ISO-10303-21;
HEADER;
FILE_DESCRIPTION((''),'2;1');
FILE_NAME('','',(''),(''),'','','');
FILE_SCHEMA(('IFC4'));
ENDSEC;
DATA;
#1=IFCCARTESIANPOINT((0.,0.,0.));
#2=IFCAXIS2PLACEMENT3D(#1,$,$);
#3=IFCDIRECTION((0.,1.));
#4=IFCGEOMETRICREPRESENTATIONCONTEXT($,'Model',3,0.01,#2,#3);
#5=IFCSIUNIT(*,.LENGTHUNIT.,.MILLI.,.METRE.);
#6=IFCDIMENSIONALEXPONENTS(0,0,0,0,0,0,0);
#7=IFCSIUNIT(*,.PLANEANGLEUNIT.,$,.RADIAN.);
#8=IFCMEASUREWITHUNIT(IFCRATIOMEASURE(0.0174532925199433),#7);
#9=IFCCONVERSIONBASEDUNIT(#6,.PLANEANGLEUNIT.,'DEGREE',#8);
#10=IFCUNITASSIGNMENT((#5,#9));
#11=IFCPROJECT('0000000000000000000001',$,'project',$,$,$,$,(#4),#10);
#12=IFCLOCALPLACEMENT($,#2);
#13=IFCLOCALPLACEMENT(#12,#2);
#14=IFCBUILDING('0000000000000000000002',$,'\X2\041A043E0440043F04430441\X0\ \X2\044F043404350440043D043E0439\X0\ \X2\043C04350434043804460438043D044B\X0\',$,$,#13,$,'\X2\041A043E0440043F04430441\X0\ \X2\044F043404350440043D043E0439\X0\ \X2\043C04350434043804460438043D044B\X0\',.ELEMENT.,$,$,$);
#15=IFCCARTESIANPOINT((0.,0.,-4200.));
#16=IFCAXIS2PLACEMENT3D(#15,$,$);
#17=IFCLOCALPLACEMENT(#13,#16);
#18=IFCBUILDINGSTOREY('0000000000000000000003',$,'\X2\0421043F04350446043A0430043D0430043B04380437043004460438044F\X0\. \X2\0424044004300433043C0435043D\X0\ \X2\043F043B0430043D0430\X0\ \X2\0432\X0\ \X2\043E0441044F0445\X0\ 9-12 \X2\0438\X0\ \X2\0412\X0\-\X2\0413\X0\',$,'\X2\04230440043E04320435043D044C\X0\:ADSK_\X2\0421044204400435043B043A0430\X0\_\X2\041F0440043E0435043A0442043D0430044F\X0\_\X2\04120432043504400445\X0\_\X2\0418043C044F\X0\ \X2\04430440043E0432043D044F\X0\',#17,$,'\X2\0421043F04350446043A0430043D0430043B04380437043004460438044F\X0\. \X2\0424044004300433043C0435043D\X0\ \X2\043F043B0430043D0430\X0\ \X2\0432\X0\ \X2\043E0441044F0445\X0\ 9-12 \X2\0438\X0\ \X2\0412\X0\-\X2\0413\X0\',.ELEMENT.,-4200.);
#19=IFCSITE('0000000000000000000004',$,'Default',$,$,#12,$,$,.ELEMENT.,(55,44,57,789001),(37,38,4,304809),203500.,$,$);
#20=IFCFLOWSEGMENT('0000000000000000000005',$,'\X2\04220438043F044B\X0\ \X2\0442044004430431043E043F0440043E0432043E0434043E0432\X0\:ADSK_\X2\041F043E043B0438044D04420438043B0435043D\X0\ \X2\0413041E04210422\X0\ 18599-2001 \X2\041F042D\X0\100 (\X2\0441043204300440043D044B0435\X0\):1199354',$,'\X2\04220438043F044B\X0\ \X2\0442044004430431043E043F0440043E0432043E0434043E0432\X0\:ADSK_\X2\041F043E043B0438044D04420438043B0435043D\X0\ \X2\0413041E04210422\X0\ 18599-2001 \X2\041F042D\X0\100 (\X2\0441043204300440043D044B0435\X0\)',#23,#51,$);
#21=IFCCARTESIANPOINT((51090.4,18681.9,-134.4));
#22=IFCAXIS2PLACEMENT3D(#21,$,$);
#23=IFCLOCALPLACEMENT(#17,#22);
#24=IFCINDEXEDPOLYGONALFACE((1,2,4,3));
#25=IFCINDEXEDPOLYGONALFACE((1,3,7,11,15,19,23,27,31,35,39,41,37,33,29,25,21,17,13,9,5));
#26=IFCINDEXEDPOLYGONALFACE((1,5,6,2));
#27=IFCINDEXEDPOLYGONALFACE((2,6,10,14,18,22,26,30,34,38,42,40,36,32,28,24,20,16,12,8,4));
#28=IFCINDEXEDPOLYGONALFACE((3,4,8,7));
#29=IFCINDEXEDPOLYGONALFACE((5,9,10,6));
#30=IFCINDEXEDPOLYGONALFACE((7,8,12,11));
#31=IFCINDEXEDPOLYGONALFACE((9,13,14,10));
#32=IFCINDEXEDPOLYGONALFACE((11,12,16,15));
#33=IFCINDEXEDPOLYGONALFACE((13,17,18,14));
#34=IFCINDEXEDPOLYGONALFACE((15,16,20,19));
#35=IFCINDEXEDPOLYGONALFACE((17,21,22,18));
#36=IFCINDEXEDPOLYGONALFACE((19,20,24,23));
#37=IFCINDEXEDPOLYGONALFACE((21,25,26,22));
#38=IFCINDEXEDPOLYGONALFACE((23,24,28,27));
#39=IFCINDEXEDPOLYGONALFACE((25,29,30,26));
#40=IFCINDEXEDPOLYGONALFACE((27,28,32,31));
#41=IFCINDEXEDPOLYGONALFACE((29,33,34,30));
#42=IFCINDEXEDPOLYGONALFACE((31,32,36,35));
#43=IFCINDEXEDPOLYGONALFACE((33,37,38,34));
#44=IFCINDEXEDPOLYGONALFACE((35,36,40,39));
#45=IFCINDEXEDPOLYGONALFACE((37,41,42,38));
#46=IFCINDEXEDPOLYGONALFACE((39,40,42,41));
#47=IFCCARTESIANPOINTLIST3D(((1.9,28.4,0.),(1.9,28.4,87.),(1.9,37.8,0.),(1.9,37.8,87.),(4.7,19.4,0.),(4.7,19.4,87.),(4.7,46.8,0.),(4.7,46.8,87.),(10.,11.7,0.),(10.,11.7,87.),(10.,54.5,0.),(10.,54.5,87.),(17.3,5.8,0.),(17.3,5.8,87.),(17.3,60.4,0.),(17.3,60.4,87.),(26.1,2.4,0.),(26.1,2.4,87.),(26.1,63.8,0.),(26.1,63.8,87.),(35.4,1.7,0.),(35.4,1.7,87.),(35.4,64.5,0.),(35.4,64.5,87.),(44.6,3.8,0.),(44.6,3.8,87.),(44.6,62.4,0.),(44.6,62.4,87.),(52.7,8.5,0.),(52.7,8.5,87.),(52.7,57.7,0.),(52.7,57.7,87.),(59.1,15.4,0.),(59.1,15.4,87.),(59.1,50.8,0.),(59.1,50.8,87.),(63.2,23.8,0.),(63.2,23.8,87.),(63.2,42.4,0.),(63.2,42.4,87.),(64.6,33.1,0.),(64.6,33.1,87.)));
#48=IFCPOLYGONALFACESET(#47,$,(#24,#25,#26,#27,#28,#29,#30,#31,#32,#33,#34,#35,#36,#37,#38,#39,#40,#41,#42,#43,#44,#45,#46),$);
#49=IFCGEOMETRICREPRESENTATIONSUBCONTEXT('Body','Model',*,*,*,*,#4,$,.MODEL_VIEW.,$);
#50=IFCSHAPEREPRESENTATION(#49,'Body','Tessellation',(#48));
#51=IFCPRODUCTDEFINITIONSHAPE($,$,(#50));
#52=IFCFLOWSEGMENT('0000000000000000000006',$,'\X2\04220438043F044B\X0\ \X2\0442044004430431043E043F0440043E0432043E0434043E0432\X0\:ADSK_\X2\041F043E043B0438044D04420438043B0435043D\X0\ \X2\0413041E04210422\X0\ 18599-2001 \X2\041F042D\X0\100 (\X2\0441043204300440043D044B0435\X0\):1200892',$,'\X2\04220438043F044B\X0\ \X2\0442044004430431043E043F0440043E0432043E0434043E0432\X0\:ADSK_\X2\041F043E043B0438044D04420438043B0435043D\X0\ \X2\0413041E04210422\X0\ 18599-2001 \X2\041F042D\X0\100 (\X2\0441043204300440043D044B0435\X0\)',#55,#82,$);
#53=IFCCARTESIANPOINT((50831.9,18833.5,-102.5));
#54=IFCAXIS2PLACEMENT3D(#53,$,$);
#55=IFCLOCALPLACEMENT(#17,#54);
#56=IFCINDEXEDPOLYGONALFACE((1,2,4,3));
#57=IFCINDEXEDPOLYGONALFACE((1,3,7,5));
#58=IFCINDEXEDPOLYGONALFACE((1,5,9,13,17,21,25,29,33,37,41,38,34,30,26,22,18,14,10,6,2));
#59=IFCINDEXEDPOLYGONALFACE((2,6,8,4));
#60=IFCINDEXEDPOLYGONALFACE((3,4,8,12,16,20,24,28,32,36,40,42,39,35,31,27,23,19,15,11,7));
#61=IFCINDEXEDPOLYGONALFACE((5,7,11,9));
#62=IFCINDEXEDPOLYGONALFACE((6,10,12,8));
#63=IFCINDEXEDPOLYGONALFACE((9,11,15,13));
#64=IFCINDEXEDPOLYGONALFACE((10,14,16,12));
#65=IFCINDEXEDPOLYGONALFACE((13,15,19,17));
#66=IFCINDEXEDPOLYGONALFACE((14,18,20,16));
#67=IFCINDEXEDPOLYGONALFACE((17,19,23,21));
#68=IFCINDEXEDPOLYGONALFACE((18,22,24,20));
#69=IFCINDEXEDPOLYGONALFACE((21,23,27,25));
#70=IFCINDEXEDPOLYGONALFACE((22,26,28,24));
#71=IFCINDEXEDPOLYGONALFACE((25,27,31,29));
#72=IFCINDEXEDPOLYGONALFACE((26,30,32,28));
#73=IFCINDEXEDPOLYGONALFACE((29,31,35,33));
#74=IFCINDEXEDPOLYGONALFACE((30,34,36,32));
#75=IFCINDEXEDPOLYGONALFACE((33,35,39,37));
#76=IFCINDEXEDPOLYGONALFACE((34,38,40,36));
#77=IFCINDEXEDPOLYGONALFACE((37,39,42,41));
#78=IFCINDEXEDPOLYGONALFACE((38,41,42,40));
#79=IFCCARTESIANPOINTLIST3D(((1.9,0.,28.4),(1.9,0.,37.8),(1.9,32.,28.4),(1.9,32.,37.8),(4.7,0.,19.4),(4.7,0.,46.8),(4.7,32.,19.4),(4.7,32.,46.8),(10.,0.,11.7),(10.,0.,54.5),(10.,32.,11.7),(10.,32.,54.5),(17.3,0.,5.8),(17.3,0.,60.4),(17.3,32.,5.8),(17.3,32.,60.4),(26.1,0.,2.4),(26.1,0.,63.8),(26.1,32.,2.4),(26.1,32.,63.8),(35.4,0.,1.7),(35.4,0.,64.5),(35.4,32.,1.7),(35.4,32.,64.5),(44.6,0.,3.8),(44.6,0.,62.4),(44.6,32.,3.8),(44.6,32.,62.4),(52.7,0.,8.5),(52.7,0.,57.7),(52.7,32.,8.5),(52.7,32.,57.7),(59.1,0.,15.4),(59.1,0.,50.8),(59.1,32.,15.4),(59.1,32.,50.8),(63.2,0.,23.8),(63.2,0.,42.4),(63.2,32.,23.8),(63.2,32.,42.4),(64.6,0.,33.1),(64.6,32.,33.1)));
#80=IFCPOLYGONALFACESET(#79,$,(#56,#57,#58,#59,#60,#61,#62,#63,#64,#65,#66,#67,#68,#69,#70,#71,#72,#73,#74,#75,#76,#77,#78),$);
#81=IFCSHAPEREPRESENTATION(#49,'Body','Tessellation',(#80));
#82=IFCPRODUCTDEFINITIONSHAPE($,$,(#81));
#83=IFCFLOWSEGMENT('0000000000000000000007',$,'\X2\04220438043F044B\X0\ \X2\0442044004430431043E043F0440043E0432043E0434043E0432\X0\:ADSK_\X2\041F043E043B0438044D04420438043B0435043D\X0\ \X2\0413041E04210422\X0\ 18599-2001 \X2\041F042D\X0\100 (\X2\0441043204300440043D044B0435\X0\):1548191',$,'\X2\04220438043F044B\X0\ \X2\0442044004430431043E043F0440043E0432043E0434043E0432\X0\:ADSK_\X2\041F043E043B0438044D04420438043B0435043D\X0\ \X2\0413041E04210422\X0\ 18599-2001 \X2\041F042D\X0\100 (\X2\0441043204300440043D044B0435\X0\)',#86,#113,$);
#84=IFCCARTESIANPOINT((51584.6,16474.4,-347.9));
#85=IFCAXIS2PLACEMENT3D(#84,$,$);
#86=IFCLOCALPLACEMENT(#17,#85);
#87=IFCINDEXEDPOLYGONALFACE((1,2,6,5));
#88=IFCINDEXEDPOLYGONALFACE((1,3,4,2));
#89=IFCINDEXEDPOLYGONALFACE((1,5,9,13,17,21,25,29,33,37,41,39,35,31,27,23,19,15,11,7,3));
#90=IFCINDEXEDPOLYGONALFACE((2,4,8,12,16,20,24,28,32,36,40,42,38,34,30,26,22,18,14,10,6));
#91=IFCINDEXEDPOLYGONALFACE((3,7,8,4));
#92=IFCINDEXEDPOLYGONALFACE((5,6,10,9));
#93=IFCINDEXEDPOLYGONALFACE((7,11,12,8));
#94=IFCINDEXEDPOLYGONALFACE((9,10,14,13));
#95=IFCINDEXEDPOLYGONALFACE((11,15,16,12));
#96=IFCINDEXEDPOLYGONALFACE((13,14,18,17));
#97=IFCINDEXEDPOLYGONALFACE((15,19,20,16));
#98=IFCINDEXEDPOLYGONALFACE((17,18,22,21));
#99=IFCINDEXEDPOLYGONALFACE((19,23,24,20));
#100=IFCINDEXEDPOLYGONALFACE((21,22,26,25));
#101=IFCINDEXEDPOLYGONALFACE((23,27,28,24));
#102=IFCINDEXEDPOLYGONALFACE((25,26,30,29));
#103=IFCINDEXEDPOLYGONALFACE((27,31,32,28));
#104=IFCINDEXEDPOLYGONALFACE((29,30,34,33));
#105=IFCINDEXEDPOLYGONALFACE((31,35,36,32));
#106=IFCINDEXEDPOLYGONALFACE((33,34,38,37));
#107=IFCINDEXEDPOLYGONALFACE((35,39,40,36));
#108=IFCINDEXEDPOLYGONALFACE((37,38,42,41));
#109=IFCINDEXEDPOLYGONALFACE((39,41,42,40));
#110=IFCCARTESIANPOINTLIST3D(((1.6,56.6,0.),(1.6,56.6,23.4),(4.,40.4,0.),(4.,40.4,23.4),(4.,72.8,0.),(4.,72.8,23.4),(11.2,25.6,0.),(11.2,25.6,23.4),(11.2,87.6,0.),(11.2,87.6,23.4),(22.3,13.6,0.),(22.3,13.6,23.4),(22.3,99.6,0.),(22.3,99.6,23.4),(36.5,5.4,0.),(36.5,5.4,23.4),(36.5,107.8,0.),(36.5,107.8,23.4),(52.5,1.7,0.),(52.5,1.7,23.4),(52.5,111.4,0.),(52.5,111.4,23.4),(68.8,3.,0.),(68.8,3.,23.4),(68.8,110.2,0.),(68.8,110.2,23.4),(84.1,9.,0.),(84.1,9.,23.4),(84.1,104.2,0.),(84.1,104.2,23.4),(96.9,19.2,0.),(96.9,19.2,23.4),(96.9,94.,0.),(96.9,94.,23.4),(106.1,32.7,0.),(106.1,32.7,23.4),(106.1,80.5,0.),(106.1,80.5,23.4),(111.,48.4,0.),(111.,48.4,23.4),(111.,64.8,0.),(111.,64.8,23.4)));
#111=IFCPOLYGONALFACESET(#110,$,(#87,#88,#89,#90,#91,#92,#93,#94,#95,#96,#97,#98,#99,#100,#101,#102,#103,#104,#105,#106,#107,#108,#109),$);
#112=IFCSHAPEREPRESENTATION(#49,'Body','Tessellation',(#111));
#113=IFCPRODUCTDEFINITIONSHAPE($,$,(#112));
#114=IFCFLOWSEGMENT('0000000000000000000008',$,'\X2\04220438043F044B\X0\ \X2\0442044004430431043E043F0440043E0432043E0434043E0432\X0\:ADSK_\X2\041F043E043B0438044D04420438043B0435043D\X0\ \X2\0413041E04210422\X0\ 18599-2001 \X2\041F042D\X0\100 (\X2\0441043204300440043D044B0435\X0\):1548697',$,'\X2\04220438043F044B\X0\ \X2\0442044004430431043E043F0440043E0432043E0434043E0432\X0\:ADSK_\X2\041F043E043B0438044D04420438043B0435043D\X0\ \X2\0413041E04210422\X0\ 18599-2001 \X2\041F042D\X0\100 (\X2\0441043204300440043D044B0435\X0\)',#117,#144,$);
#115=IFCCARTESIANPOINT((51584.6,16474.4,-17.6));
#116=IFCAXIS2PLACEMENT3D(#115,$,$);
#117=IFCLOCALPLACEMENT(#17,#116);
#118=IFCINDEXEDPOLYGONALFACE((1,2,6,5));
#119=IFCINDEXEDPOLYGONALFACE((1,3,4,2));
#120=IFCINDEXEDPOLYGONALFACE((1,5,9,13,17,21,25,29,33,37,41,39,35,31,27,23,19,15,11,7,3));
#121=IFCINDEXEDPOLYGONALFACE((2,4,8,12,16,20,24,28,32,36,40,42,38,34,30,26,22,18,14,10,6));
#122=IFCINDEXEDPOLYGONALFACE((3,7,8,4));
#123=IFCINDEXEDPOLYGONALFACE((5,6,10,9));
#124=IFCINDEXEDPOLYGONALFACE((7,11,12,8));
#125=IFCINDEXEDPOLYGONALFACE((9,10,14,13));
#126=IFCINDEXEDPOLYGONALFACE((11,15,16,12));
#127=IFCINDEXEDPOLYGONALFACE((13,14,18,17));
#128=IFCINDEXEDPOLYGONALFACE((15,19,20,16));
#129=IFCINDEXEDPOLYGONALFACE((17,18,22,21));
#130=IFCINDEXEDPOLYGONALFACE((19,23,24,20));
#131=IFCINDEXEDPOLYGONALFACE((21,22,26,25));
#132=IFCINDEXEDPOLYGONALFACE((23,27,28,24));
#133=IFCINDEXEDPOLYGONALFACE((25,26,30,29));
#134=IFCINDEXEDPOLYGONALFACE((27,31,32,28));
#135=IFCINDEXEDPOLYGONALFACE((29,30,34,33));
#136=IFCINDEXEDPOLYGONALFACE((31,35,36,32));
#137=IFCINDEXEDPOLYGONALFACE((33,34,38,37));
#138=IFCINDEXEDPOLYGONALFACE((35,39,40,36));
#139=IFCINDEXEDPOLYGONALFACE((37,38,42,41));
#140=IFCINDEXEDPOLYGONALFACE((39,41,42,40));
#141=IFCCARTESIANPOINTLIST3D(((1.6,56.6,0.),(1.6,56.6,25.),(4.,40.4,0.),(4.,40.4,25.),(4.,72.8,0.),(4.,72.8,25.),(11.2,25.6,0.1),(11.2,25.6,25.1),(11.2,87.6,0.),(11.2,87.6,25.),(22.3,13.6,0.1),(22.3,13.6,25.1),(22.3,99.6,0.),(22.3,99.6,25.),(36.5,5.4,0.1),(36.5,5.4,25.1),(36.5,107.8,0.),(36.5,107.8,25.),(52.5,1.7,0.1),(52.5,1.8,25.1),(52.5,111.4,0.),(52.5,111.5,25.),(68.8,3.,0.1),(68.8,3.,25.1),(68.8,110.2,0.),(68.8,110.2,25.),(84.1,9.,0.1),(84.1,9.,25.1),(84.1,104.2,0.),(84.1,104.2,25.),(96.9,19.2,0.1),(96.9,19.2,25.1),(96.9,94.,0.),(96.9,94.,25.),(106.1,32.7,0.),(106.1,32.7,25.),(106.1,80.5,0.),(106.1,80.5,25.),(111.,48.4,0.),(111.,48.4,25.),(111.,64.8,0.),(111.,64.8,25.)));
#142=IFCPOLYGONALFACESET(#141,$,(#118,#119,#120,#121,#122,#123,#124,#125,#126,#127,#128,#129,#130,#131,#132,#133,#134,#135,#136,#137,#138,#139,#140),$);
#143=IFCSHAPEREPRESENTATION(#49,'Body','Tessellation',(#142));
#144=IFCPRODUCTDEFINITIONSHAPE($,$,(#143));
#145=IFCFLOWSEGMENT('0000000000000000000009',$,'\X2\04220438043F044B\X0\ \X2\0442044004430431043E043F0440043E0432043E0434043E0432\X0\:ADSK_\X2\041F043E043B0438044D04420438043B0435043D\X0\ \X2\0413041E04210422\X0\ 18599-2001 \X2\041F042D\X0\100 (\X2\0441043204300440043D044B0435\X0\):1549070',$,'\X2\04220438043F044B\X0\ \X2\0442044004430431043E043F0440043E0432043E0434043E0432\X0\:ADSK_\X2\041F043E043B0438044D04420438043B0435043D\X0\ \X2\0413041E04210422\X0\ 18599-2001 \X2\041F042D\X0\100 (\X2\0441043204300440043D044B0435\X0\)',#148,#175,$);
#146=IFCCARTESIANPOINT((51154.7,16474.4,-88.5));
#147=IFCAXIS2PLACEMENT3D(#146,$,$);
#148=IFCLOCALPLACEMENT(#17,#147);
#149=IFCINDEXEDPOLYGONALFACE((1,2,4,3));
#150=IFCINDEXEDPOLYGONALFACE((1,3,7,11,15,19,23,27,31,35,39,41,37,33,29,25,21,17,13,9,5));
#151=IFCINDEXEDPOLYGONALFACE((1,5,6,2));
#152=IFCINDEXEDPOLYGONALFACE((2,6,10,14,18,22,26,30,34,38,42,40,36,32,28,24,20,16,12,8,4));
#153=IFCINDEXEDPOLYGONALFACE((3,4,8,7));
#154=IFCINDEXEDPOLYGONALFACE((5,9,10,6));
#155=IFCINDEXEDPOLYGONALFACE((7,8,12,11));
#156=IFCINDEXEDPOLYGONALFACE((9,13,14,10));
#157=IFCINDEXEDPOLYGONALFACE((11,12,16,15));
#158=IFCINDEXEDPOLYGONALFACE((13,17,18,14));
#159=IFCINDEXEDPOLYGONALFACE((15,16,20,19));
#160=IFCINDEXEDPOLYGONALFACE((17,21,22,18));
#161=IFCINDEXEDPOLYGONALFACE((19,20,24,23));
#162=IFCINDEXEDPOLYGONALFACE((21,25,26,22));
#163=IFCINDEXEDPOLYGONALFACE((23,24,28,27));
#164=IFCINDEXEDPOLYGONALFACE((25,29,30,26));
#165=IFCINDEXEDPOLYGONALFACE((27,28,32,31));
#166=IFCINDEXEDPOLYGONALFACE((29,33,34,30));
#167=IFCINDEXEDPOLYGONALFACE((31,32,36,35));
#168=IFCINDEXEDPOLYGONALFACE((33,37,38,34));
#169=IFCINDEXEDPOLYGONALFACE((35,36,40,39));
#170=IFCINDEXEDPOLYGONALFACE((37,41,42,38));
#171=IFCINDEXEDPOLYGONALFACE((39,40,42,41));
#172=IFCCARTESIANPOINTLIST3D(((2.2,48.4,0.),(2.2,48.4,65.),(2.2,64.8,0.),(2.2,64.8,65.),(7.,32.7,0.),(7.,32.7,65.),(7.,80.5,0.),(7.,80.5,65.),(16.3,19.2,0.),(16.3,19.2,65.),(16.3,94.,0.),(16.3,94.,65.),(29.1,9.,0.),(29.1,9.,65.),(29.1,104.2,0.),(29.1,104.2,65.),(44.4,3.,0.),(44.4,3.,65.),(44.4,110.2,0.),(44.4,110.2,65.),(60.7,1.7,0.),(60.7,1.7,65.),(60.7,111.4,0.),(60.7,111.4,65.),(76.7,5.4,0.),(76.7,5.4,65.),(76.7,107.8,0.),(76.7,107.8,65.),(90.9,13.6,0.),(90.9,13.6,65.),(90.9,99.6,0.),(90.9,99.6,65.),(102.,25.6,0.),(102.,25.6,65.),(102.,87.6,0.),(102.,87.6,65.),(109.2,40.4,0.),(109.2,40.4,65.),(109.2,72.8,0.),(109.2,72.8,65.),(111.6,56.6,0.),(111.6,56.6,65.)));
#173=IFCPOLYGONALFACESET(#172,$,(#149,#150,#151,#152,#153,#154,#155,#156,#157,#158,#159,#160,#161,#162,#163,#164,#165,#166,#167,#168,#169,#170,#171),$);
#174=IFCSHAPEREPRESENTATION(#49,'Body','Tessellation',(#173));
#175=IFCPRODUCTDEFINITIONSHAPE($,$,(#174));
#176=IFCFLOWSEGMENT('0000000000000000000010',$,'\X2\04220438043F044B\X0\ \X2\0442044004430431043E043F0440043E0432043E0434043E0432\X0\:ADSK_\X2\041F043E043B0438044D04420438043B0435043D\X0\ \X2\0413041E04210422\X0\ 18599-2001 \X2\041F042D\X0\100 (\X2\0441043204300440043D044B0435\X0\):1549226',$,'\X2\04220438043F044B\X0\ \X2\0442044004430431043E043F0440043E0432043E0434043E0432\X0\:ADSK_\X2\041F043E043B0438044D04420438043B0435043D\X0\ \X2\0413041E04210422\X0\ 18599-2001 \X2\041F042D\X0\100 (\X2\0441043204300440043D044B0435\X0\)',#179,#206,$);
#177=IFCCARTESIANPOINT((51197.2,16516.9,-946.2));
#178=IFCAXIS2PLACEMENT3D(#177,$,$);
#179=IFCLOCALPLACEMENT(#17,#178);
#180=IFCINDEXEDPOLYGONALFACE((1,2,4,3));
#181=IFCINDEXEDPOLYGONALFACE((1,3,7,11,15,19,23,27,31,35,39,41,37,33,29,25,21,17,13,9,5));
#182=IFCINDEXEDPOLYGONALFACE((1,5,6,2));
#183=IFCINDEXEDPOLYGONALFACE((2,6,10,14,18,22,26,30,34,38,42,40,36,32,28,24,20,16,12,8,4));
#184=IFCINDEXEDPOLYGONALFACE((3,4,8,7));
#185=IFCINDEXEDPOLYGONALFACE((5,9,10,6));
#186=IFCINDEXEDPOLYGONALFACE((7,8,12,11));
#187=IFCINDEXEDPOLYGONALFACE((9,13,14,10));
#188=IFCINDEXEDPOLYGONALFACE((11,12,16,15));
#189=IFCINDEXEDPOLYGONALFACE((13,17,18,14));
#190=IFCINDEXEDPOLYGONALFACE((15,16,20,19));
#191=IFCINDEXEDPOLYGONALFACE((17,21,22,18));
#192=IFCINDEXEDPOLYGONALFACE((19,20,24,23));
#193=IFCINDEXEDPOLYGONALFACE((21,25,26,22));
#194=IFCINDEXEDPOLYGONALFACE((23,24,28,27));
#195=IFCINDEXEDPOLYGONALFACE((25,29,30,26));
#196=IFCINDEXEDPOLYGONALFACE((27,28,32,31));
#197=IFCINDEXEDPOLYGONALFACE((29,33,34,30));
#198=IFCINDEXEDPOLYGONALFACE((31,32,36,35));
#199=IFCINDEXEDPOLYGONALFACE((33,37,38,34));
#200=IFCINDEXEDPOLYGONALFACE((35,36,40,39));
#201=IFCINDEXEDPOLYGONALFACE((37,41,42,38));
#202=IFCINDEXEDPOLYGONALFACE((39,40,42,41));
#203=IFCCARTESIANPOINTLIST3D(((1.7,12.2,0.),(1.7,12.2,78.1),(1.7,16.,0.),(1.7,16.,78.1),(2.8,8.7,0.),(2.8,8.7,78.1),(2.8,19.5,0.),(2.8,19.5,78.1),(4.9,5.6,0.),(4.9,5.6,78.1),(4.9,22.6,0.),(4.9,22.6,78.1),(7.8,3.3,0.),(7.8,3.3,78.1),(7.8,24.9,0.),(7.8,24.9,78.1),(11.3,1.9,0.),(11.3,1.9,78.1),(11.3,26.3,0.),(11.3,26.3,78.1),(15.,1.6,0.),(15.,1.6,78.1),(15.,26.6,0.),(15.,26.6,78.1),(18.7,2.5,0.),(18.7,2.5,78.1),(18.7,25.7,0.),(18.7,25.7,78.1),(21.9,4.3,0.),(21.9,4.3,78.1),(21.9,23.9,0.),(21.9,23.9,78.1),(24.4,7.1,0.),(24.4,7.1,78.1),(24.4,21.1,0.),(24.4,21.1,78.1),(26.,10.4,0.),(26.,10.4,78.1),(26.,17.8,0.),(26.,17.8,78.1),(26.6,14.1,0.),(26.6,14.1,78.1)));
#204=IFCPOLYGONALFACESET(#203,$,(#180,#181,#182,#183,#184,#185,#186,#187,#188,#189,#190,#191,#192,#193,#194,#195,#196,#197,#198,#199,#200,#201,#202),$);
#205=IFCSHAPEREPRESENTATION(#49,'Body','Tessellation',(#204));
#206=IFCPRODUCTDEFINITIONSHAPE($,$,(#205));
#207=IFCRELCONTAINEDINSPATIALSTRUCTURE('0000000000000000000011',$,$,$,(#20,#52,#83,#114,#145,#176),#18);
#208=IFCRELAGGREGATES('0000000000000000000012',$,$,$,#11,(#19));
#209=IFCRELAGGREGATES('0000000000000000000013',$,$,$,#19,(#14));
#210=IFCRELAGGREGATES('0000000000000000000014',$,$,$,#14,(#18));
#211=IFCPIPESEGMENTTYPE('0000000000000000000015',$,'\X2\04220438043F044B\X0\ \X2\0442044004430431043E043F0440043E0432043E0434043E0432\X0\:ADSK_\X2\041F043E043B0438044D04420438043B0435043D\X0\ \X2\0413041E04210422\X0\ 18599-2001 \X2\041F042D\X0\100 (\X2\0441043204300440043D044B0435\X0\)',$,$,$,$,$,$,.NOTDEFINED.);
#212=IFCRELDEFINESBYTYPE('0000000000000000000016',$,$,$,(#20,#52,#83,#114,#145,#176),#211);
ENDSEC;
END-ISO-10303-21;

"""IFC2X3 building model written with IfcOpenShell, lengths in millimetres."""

from ifc_helpers import new_model, entity, si_unit, converted_unit, direction, frame, frame_2d, origin, origin_2d_with_axis, place, context, subcontext, project, spatial, circle, extrude, type_object, element, save


model = new_model("IFC2X3")

# Units and contexts
model_context = context("Model", 3, precision=0.01, world=origin(), true_north=direction((0.0, 1.0)))
body_context = subcontext(model_context, "Body", "Model", "MODEL_VIEW")
ifc_project = project(units=[si_unit("LENGTHUNIT", "METRE", prefix="MILLI"), converted_unit("PLANEANGLEUNIT", "DEGREE", entity("IfcRatioMeasure", 0.0174532925199433), si_unit("PLANEANGLEUNIT", "RADIAN"), dimensions=[0, 0, 0, 0, 0, 0, 0])], contexts=[model_context])

# Site, building, storey
site_placement = place(None, frame((0.0, 0.0, 0.0)))
site = spatial("IfcSite", under=ifc_project, at=site_placement, Name="Default", CompositionType="ELEMENT", RefLatitude=(55, 44, 57, 789001), RefLongitude=(37, 38, 4, 304809), RefElevation=203500.0)
building_placement = place(site_placement, origin())
building = spatial("IfcBuilding", under=site, at=building_placement, Name="Корпус ядерной медицины", LongName="Корпус ядерной медицины", CompositionType="ELEMENT")
storey_placement = place(building_placement, frame((0.0, 0.0, -4200.0)))
storey = spatial("IfcBuildingStorey", under=building, at=storey_placement, Name="Спецканализация. Фрагмен плана в осях 9-12 и В-Г", ObjectType="Уровень:ADSK_Стрелка_Проектная_Вверх_Имя уровня", LongName="Спецканализация. Фрагмен плана в осях 9-12 и В-Г", CompositionType="ELEMENT", Elevation=-4200.0)

# Flow segments
pipe_segment_type = type_object("IfcPipeSegmentType", Name="Типы трубопроводов:ADSK_Полиэтилен ГОСТ 18599-2001 ПЭ100 (сварные)", PredefinedType="NOTDEFINED")
flow_segment_1_placement = place(storey_placement, frame((51090.4, 18681.9, -134.4)))
element("IfcFlowSegment", 1, at=flow_segment_1_placement, inside=storey, type_object=pipe_segment_type, Name="Типы трубопроводов:ADSK_Полиэтилен ГОСТ 18599-2001 ПЭ100 (сварные):1199354", ObjectType="Типы трубопроводов:ADSK_Полиэтилен ГОСТ 18599-2001 ПЭ100 (сварные)", context=body_context, shape_type="SweptSolid", body=[
    extrude(circle(Radius=31.5, at=frame_2d((0.0, 0.0), x_axis=(1.0, 0.0))), frame((33.1, 33.1, 0.0)), (0.0, 0.0, 1.0), 87.0),
])
flow_segment_2_placement = place(storey_placement, frame((50831.9, 18833.5, -102.5)))
element("IfcFlowSegment", 2, at=flow_segment_2_placement, inside=storey, type_object=pipe_segment_type, Name="Типы трубопроводов:ADSK_Полиэтилен ГОСТ 18599-2001 ПЭ100 (сварные):1200892", ObjectType="Типы трубопроводов:ADSK_Полиэтилен ГОСТ 18599-2001 ПЭ100 (сварные)", context=body_context, shape_type="SweptSolid", body=[
    extrude(circle(Radius=31.5, at=origin_2d_with_axis()), frame((33.1, 0.0, 33.1), z_axis=(0.0, 1.0, 0.0), x_axis=(1.0, 0.0, 0.0)), (0.0, 0.0, 1.0), 32.0),
])
flow_segment_3_placement = place(storey_placement, frame((51584.6, 16474.4, -347.9)))
element("IfcFlowSegment", 3, at=flow_segment_3_placement, inside=storey, type_object=pipe_segment_type, Name="Типы трубопроводов:ADSK_Полиэтилен ГОСТ 18599-2001 ПЭ100 (сварные):1548191", ObjectType="Типы трубопроводов:ADSK_Полиэтилен ГОСТ 18599-2001 ПЭ100 (сварные)", context=body_context, shape_type="SweptSolid", body=[
    extrude(circle(Radius=55.0, at=origin_2d_with_axis()), frame((56.6, 56.6, 0.0), z_axis=(-0.000006, 0.0, 1.0), x_axis=(-1.0, 0.0, -0.000006)), (0.0, 0.0, 1.0), 23.4),
])
flow_segment_4_placement = place(storey_placement, frame((51584.6, 16474.4, -17.6)))
element("IfcFlowSegment", 4, at=flow_segment_4_placement, inside=storey, type_object=pipe_segment_type, Name="Типы трубопроводов:ADSK_Полиэтилен ГОСТ 18599-2001 ПЭ100 (сварные):1548697", ObjectType="Типы трубопроводов:ADSK_Полиэтилен ГОСТ 18599-2001 ПЭ100 (сварные)", context=body_context, shape_type="SweptSolid", body=[
    extrude(circle(Radius=55.0, at=origin_2d_with_axis()), frame((56.6, 56.6, 0.0), z_axis=(0.0, 0.000608, 1.0), x_axis=(-1.0, 0.0, 0.0)), (0.0, 0.0, 1.0), 25.0),
])
flow_segment_5_placement = place(storey_placement, frame((51154.7, 16474.4, -88.5)))
element("IfcFlowSegment", 5, at=flow_segment_5_placement, inside=storey, type_object=pipe_segment_type, Name="Типы трубопроводов:ADSK_Полиэтилен ГОСТ 18599-2001 ПЭ100 (сварные):1549070", ObjectType="Типы трубопроводов:ADSK_Полиэтилен ГОСТ 18599-2001 ПЭ100 (сварные)", context=body_context, shape_type="SweptSolid", body=[
    extrude(circle(Radius=55.0, at=origin_2d_with_axis()), frame((56.6, 56.6, 0.0)), (0.0, 0.0, 1.0), 65.0),
])
flow_segment_6_placement = place(storey_placement, frame((51197.2, 16516.9, -946.2)))
element("IfcFlowSegment", 6, at=flow_segment_6_placement, inside=storey, type_object=pipe_segment_type, Name="Типы трубопроводов:ADSK_Полиэтилен ГОСТ 18599-2001 ПЭ100 (сварные):1549226", ObjectType="Типы трубопроводов:ADSK_Полиэтилен ГОСТ 18599-2001 ПЭ100 (сварные)", context=body_context, shape_type="SweptSolid", body=[
    extrude(circle(Radius=12.5, at=origin_2d_with_axis()), frame((14.1, 14.1, 0.0)), (0.0, 0.0, 1.0), 78.1),
])

save(model, "model.ifc")
